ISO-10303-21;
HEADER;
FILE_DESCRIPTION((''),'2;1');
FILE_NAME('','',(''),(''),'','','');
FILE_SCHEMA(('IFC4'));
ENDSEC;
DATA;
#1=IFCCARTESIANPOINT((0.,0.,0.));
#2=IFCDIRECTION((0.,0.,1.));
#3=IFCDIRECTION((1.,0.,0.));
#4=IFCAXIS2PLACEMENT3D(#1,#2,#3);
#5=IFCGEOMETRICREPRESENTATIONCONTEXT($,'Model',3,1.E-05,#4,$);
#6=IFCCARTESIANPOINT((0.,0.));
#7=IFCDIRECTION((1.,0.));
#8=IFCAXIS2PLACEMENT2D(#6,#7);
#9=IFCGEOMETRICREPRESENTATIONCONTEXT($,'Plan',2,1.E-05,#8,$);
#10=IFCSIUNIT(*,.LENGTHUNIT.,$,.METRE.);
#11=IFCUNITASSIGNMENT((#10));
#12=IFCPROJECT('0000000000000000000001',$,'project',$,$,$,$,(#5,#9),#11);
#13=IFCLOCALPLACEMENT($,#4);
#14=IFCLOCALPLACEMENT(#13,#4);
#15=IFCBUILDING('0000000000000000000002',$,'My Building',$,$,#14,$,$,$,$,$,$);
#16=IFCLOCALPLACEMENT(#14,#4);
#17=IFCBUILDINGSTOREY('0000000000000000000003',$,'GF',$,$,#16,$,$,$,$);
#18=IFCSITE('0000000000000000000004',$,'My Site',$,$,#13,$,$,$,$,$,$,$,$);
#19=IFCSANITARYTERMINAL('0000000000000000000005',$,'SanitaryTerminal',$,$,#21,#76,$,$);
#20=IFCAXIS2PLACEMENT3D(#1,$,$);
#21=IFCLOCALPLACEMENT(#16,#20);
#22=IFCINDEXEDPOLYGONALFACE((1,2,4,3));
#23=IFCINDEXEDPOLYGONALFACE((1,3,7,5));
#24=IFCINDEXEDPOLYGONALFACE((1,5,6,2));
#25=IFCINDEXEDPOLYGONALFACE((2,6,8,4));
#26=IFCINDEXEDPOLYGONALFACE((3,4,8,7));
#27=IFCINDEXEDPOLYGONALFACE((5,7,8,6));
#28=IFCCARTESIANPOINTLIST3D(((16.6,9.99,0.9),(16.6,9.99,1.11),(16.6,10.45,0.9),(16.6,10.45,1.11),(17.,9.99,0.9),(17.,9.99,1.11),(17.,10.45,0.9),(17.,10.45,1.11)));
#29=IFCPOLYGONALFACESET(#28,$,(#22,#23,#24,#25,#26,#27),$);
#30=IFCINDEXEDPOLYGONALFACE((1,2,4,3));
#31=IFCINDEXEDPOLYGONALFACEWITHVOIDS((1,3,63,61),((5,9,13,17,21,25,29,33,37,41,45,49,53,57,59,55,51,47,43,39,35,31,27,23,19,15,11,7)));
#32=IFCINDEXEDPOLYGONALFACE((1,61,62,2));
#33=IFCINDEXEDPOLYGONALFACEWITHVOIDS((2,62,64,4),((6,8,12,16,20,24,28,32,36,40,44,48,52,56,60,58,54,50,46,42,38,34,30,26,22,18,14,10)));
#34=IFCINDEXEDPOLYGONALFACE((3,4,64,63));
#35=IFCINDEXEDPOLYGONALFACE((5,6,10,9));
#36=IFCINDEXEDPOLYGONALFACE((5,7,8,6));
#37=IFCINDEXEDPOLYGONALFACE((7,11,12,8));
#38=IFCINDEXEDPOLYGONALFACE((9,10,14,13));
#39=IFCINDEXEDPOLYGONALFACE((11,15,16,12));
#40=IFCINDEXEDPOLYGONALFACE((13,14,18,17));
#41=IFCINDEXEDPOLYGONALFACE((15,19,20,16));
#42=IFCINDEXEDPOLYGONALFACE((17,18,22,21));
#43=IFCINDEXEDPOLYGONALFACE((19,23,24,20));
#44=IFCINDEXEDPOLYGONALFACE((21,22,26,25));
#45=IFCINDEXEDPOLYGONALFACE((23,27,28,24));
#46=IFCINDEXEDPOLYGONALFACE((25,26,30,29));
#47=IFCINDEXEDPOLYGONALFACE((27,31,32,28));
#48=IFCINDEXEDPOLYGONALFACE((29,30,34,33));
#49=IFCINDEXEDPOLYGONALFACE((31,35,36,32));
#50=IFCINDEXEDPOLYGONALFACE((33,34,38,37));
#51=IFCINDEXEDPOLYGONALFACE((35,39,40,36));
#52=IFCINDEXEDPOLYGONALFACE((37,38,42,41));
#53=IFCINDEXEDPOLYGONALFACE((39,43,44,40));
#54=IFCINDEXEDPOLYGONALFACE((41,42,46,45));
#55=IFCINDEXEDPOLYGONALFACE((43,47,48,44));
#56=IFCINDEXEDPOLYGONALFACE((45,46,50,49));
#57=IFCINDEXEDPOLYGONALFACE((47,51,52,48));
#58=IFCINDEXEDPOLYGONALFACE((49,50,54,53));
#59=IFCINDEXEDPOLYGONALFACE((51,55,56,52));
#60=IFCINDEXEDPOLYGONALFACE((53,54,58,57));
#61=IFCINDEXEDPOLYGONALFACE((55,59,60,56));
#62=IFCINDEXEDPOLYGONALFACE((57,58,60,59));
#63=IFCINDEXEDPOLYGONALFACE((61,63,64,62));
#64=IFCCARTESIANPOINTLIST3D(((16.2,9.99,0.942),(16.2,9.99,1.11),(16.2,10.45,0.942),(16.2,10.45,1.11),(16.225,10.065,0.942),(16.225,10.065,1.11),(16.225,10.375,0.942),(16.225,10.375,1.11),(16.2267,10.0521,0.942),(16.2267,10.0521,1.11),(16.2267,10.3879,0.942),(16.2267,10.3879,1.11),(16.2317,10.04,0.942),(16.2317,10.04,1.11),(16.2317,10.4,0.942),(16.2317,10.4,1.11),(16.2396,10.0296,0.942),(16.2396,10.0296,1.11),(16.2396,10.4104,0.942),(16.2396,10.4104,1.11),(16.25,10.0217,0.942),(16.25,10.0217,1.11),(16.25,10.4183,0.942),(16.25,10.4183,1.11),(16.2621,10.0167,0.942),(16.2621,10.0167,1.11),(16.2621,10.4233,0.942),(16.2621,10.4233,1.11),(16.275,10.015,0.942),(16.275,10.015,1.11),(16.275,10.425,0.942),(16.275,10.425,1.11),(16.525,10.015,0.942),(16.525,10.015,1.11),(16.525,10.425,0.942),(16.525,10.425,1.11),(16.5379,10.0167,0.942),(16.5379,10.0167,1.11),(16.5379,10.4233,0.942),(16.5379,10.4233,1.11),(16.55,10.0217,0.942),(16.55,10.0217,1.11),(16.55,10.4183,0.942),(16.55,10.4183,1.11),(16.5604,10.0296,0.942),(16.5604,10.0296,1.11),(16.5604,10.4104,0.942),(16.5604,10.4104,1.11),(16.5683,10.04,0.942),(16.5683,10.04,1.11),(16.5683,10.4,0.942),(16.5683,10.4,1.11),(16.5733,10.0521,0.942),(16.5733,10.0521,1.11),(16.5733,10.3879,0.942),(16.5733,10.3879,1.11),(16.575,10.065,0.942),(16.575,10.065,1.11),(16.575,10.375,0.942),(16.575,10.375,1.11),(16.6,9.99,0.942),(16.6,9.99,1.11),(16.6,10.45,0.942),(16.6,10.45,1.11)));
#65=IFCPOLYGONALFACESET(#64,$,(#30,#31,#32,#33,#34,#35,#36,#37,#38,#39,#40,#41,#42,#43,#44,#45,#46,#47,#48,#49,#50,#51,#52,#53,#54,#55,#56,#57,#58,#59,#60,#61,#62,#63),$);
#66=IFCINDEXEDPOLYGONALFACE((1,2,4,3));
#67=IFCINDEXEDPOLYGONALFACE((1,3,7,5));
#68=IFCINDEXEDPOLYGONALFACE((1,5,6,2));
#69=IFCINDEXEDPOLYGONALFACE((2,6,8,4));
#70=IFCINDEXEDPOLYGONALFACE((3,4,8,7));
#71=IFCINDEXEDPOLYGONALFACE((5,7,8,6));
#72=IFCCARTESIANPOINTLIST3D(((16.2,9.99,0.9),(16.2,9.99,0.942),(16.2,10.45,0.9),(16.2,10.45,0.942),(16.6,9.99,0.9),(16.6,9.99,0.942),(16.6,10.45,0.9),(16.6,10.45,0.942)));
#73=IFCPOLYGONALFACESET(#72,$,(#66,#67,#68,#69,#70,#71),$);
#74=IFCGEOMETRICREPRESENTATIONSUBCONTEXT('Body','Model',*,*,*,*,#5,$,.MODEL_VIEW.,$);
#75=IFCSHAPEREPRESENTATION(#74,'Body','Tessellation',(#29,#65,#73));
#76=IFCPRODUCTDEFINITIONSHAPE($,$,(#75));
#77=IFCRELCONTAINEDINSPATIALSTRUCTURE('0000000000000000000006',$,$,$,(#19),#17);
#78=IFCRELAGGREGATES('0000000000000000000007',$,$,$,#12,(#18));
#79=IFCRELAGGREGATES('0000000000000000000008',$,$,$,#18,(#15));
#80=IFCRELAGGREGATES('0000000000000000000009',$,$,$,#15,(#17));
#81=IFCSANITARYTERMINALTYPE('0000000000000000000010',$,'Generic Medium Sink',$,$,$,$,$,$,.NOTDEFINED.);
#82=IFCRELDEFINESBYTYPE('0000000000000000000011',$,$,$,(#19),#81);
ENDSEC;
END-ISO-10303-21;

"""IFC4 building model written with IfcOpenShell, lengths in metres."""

from ifc_helpers import new_model, entity, si_unit, frame, origin_with_axes, origin_2d_with_axis, place, context, subcontext, project, spatial, line, indexed_curve, outline, extrude, shape, source, transform, mapped, type_object, type_shapes, element, save


model = new_model("IFC4")

# Units and contexts
model_context = context("Model", 3, precision=1e-05, world=origin_with_axes())
plan_context = context("Plan", 2, precision=1e-05, world=origin_2d_with_axis())
body_context_1 = subcontext(model_context, "Body", "Model", "MODEL_VIEW")
body_context_2 = subcontext(plan_context, "Body", "Plan", "PLAN_VIEW")
ifc_project = project(units=[si_unit("LENGTHUNIT", "METRE")], contexts=[model_context, plan_context])

# Site, building, storey
site_placement = place(None, origin_with_axes())
site = spatial("IfcSite", under=ifc_project, at=site_placement, Name="My Site")
building_placement = place(site_placement, origin_with_axes())
building = spatial("IfcBuilding", under=site, at=building_placement, Name="My Building")
storey_placement = place(building_placement, origin_with_axes())
storey = spatial("IfcBuildingStorey", under=building, at=storey_placement, Name="GF")

# Sanitary terminal
sanitary_terminal_type_1 = type_object("IfcSanitaryTerminalType", Name="Generic Medium Sink", PredefinedType="NOTDEFINED")
shared_indexed_poly_curve = entity("IfcIndexedPolyCurve", entity("IfcCartesianPointList2D", [[0.4, 0.0], [0.8, 0.0], [0.8, 0.46], [0.4, 0.46]]), [entity("IfcLineIndex", [1, 2, 3, 4, 1])])
shared_shape_1 = source(origin_with_axes(), body_context_1, "Body", "SweptSolid", [
    extrude(outline(indexed_curve([(0.0, 0.0), (0.4, 0.0), (0.4, 0.46), (0.0, 0.46)], segments=[line(1, 2, 3, 4, 1)])), frame((-0.4, -0.46, 0.0), z_axis=(0.0, 0.0, 1.0), x_axis=(1.0, 0.0, 0.0)), (0.0, 0.0, 1.0), 0.21),
    entity("IfcExtrudedAreaSolid", entity("IfcArbitraryProfileDefWithVoids", "AREA", None, shared_indexed_poly_curve, [entity("IfcIndexedPolyCurve", entity("IfcCartesianPointList2D", [[0.425, 0.075], [0.4396, 0.0396], [0.475, 0.025], [0.725, 0.025], [0.7604, 0.0396], [0.775, 0.075], [0.775, 0.385], [0.7604, 0.4204], [0.725, 0.435], [0.475, 0.435], [0.4396, 0.4204], [0.425, 0.385]]), [entity("IfcLineIndex", [12, 1]), entity("IfcArcIndex", [1, 2, 3]), entity("IfcLineIndex", [3, 4]), entity("IfcArcIndex", [4, 5, 6]), entity("IfcLineIndex", [6, 7]), entity("IfcArcIndex", [7, 8, 9]), entity("IfcLineIndex", [9, 10]), entity("IfcArcIndex", [10, 11, 12]), entity("IfcLineIndex", [12, 1])])]), entity("IfcAxis2Placement3D", entity("IfcCartesianPoint", [-0.4, -0.46, 0.042]), entity("IfcDirection", [0.0, 0.0, 1.0]), entity("IfcDirection", [1.0, 0.0, 0.0])), entity("IfcDirection", [0.0, 0.0, 1.0]), 0.168),
    entity("IfcExtrudedAreaSolid", entity("IfcArbitraryClosedProfileDef", "AREA", None, shared_indexed_poly_curve), entity("IfcAxis2Placement3D", entity("IfcCartesianPoint", [-0.4, -0.46, 0.0]), entity("IfcDirection", [0.0, 0.0, 1.0]), entity("IfcDirection", [1.0, 0.0, 0.0])), entity("IfcDirection", [0.0, 0.0, 1.0]), 0.042),
])
shared_shape_2 = source(origin_with_axes(), body_context_2, "Body", "Curve2D", [
    entity("IfcIndexedPolyCurve", entity("IfcCartesianPointList2D", [[-0.4, -0.46], [0.4, -0.46], [0.4, 0.0], [-0.4, 0.0]]), [entity("IfcLineIndex", [1, 2, 3, 4, 1])]),
    entity("IfcIndexedPolyCurve", entity("IfcCartesianPointList2D", [[0.025, -0.385], [0.0396, -0.4204], [0.075, -0.435], [0.325, -0.435], [0.3604, -0.4204], [0.375, -0.385], [0.375, -0.075], [0.3604, -0.0396], [0.325, -0.025], [0.075, -0.025], [0.0396, -0.0396], [0.025, -0.075]]), [entity("IfcLineIndex", [12, 1]), entity("IfcArcIndex", [1, 2, 3]), entity("IfcLineIndex", [3, 4]), entity("IfcArcIndex", [4, 5, 6]), entity("IfcLineIndex", [6, 7]), entity("IfcArcIndex", [7, 8, 9]), entity("IfcLineIndex", [9, 10]), entity("IfcArcIndex", [10, 11, 12]), entity("IfcLineIndex", [12, 1])]),
    entity("IfcCircle", entity("IfcAxis2Placement2D", entity("IfcCartesianPoint", [0.2, -0.125])), 0.025),
    entity("IfcIndexedPolyCurve", entity("IfcCartesianPointList2D", [[0.2, -0.0125], [0.2, -0.1325]])),
])
type_shapes(sanitary_terminal_type_1, [shared_shape_1, shared_shape_2])
for number, where, z_axis, x_axis, name in (
    (1, (16.6, 9.99, 0.9), (0.0, 0.0, 1.0), (-1.0, 0.0, 0.0), "SanitaryTerminal"),
):
    element("IfcSanitaryTerminal", number, at=place(storey_placement, frame(where, z_axis=z_axis, x_axis=x_axis)), inside=storey, type_object=sanitary_terminal_type_1, Name=name, shapes=[
        shape(body_context_1, "Body", "MappedRepresentation", [mapped(shared_shape_1, transform((0.0, 0.0, 0.0), x_axis=(1.0, 0.0, 0.0), y_axis=(0.0, 1.0, 0.0), z_axis=(0.0, 0.0, 1.0), scale=1.0))]),
        shape(body_context_2, "Body", "MappedRepresentation", [mapped(shared_shape_2, transform((0.0, 0.0, 0.0), x_axis=(1.0, 0.0, 0.0), y_axis=(0.0, 1.0, 0.0), z_axis=(0.0, 0.0, 1.0), scale=1.0))]),
    ])

save(model, "model.ifc")
